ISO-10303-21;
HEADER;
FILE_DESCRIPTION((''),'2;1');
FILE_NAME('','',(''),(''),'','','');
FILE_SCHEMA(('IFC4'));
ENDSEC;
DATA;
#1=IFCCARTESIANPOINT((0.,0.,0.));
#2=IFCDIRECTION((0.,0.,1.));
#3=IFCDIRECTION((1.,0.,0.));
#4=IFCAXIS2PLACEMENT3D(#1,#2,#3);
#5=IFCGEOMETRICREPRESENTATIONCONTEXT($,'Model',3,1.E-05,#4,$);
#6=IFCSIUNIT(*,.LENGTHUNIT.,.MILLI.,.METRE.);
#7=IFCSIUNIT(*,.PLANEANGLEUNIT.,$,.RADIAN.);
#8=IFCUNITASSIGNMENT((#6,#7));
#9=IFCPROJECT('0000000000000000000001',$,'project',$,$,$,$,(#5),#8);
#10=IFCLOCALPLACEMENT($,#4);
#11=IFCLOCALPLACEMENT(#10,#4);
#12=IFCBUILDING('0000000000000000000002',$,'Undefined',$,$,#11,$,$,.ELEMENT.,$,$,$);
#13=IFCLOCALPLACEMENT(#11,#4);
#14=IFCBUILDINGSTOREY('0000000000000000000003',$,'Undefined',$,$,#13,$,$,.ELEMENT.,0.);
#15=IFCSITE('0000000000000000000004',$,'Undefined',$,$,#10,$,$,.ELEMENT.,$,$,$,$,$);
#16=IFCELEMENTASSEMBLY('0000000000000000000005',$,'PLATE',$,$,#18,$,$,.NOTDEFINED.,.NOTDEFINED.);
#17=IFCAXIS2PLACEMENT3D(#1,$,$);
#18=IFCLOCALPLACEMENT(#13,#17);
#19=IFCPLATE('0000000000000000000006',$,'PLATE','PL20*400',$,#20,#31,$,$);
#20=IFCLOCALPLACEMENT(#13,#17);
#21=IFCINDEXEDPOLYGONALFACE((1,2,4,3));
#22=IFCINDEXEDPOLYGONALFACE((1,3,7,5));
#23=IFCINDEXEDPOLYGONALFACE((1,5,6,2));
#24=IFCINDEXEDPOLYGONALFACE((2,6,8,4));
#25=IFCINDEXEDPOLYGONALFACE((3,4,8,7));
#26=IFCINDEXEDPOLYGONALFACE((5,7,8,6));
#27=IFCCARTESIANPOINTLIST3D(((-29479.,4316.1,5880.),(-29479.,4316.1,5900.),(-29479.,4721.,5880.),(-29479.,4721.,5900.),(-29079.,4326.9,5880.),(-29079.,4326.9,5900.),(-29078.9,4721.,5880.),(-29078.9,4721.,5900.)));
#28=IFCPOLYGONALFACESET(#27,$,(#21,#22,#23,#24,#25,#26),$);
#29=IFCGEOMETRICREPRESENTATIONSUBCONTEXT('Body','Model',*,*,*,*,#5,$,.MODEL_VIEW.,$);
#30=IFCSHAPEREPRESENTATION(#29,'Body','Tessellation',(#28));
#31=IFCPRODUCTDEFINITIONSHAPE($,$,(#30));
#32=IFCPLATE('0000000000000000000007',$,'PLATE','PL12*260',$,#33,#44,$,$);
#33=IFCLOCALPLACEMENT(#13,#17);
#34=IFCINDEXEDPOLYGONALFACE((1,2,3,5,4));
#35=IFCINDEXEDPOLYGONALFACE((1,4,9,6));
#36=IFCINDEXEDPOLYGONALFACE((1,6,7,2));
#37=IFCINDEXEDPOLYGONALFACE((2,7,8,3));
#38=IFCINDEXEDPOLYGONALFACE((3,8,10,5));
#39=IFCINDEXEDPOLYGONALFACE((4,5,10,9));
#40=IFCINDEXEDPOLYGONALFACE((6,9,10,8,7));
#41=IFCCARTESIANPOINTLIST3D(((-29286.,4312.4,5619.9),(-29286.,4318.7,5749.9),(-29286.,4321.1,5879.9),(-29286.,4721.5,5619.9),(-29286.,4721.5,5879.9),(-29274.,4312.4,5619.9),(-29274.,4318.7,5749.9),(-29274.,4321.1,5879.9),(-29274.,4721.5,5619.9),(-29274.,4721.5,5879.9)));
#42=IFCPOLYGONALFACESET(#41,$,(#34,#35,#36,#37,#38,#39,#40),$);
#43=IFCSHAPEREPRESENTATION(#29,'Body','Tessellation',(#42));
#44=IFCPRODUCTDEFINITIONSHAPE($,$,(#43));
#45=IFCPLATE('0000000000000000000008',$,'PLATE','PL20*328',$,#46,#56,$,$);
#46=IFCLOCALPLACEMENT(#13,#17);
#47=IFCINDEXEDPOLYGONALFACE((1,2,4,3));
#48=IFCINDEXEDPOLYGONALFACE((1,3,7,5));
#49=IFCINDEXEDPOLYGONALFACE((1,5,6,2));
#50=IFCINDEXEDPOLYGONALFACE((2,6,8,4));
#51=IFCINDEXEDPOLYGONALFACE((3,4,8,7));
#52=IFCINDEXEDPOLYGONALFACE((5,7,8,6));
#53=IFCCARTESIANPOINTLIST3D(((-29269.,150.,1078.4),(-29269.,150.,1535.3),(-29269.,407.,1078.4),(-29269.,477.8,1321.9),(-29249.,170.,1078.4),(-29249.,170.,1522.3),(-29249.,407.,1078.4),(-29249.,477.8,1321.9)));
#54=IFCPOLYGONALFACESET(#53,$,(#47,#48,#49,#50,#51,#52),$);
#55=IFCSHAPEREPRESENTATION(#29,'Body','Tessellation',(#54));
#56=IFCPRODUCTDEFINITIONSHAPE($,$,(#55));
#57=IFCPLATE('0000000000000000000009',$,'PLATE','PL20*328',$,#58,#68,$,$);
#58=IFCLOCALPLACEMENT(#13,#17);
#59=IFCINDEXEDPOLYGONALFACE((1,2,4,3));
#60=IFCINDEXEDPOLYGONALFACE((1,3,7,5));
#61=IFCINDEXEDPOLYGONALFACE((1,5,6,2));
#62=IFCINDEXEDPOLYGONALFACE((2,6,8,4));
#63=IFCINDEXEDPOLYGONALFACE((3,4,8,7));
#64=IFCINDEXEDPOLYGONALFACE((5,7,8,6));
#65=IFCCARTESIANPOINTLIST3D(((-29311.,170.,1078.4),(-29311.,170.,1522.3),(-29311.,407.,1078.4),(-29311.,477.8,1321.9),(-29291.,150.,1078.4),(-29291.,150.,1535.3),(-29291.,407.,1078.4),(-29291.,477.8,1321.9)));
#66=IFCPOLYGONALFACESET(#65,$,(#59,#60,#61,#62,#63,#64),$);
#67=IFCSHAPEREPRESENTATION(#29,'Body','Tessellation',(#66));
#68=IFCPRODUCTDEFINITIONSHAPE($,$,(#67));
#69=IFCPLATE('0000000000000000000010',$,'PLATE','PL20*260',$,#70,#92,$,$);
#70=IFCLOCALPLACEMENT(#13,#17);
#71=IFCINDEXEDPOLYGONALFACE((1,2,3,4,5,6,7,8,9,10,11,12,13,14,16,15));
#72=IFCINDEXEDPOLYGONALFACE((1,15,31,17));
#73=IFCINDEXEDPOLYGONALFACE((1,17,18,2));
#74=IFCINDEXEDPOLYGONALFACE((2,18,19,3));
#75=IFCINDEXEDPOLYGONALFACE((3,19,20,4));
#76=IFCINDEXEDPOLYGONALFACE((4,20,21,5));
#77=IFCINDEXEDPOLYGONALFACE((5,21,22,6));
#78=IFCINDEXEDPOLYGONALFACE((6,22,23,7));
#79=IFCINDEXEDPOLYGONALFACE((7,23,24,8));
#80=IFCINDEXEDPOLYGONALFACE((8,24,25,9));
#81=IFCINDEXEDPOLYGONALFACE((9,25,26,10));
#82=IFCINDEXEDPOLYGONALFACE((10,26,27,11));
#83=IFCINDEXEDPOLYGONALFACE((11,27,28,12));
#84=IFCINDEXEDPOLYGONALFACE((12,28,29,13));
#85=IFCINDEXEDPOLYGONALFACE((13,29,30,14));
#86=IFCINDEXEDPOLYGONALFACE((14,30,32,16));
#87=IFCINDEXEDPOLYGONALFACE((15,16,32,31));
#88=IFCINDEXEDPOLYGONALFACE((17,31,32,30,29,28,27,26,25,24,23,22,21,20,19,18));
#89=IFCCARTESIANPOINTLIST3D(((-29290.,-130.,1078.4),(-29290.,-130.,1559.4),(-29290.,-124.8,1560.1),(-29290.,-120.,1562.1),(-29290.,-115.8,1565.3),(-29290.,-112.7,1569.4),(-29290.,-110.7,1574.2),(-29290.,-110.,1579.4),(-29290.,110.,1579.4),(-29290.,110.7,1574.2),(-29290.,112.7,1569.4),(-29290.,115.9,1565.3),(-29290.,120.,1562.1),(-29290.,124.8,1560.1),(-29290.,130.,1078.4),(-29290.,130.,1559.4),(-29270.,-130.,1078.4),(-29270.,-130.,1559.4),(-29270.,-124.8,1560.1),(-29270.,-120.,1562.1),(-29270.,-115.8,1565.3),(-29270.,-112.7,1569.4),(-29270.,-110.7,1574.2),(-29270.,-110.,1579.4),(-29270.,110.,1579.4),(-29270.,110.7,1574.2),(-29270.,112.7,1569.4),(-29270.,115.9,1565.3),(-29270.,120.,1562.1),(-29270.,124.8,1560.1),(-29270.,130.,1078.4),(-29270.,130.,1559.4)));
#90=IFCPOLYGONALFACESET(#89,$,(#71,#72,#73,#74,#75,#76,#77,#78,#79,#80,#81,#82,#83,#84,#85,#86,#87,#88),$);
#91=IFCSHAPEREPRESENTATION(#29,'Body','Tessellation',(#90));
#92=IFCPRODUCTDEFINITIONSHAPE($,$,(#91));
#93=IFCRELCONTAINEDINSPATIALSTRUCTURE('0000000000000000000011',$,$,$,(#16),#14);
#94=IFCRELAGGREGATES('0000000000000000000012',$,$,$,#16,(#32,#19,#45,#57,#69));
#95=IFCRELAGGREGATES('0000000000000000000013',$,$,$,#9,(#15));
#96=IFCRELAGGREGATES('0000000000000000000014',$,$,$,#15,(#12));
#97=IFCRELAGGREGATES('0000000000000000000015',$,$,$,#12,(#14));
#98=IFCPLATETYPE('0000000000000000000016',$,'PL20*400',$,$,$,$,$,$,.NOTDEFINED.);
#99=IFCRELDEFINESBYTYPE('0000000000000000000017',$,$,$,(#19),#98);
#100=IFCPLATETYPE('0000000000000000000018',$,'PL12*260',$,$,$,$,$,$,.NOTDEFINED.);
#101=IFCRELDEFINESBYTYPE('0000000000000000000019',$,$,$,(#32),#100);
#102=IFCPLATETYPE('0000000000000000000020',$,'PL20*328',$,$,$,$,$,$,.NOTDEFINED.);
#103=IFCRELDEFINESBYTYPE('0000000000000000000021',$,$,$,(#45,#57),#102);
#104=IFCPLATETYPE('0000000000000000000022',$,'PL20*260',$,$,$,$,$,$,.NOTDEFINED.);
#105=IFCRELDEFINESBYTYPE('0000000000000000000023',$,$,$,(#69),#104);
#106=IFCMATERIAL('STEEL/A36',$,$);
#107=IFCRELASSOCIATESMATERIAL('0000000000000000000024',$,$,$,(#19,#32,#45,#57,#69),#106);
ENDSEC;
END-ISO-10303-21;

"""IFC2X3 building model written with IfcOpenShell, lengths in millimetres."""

from ifc_helpers import new_model, si_unit, frame, frame_2d, origin_with_axes, place, context, subcontext, project, spatial, polyline, circle_curve, parameter, trimmed, segment, composite_curve, outline, extrude, boolean, material, type_object, element, aggregate, save


model = new_model("IFC2X3")

# Units and contexts
model_context = context("Model", 3, precision=1e-05, world=origin_with_axes())
body_context = subcontext(model_context, "Body", "Model", "MODEL_VIEW")
ifc_project = project(units=[si_unit("LENGTHUNIT", "METRE", prefix="MILLI"), si_unit("PLANEANGLEUNIT", "RADIAN")], contexts=[model_context])

# Site, building, storey
site_placement = place(None, origin_with_axes())
site = spatial("IfcSite", under=ifc_project, at=site_placement, Name="Undefined", CompositionType="ELEMENT")
building_placement = place(site_placement, origin_with_axes())
building = spatial("IfcBuilding", under=site, at=building_placement, Name="Undefined", CompositionType="ELEMENT")
storey_placement = place(building_placement, origin_with_axes())
storey = spatial("IfcBuildingStorey", under=building, at=storey_placement, Name="Undefined", CompositionType="ELEMENT", Elevation=0.0)

# Element assembly, plates
assembly_1_placement = place(storey_placement, origin_with_axes())
assembly_1 = element("IfcElementAssembly", 1, at=assembly_1_placement, inside=storey, Name="PLATE", AssemblyPlace="NOTDEFINED", PredefinedType="NOTDEFINED")
ifc_material_1 = material(Name="STEEL/A36")
plate_type_1 = type_object("IfcPlateType", Name="PL20*400", PredefinedType="NOTDEFINED")
plate_1_placement = place(assembly_1_placement, frame((-29078.9, 4721.0, 5890.0), z_axis=(0.0, 0.0, 1.0), x_axis=(-1.0, 0.0, 0.0)))
plate_1 = element("IfcPlate", 2, at=plate_1_placement, type_object=plate_type_1, material=ifc_material_1, Name="PLATE", Description="PL20*400", context=body_context, shape_type="SweptSolid", body=[
    extrude(outline(polyline([(0.0, 0.0), (400.1, 0.0), (400.1, 404.9), (0.1, 394.1), (0.0, 0.0)])), frame((0.0, 0.0, -10.0), z_axis=(0.0, 0.0, 1.0), x_axis=(1.0, 0.0, 0.0)), (0.0, 0.0, 1.0), 20.0),
])
plate_type_2 = type_object("IfcPlateType", Name="PL12*260", PredefinedType="NOTDEFINED")
plate_2_placement = place(assembly_1_placement, frame((-29280.0, 4721.5, 5879.9), z_axis=(-1.0, 0.0, 0.0), x_axis=(0.0, 0.0, -1.0)))
plate_2 = element("IfcPlate", 3, at=plate_2_placement, type_object=plate_type_2, material=ifc_material_1, Name="PLATE", Description="PL12*260", context=body_context, shape_type="SweptSolid", body=[
    extrude(outline(polyline([(0.0, 0.0), (260.0, 0.0), (260.0, 409.1), (130.0, 402.7), (0.0, 400.3), (0.0, 0.0)])), frame((0.0, 0.0, -6.0), z_axis=(0.0, 0.0, 1.0), x_axis=(1.0, 0.0, 0.0)), (0.0, 0.0, 1.0), 12.0),
])
plate_type_3 = type_object("IfcPlateType", Name="PL20*328", PredefinedType="NOTDEFINED")
plate_3_placement = place(assembly_1_placement, frame((-29259.0, 150.0, 1535.3), z_axis=(-1.0, 0.0, 0.0), x_axis=(0.0, 0.83796, -0.545732)))
plate_3 = element("IfcPlate", 4, at=plate_3_placement, type_object=plate_type_3, material=ifc_material_1, Name="PLATE", Description="PL20*328", context=body_context, shape_type="CSG", body=[
    boolean("DIFFERENCE", extrude(outline(polyline([(0.0, 0.0), (391.1, 0.0), (464.7, 242.6), (249.4, 382.9), (0.0, 0.0)])), frame((0.0, 0.0, -10.0), z_axis=(0.0, 0.0, 1.0), x_axis=(1.0, 0.0, 0.0)), (0.0, 0.0, 1.0), 20.0), extrude(outline(polyline([(0.0, 0.0), (20.0, 0.0), (0.0, 20.0), (0.0, 0.0)])), frame((-1.4, -2.1, -10.0), z_axis=(0.545732, 0.83796, 0.0), x_axis=(0.0, 0.0, 1.0)), (0.0, 0.0, 1.0), 462.0)),
])
plate_4_placement = place(assembly_1_placement, frame((-29301.0, 150.0, 1535.3), z_axis=(-1.0, 0.0, 0.0), x_axis=(0.0, 0.83796, -0.545732)))
plate_4 = element("IfcPlate", 5, at=plate_4_placement, type_object=plate_type_3, material=ifc_material_1, Name="PLATE", Description="PL20*328", context=body_context, shape_type="CSG", body=[
    boolean("DIFFERENCE", extrude(outline(polyline([(0.0, 0.0), (391.1, 0.0), (464.7, 242.6), (249.4, 382.9), (0.0, 0.0)])), frame((0.0, 0.0, -10.0), z_axis=(0.0, 0.0, 1.0), x_axis=(1.0, 0.0, 0.0)), (0.0, 0.0, 1.0), 20.0), extrude(outline(polyline([(0.0, 0.0), (20.0, 0.0), (20.0, 20.0), (0.0, 0.0)])), frame((-1.4, -2.1, -10.0), z_axis=(0.545732, 0.83796, 0.0), x_axis=(0.0, 0.0, 1.0)), (0.0, 0.0, 1.0), 462.0)),
])
plate_type_4 = type_object("IfcPlateType", Name="PL20*260", PredefinedType="NOTDEFINED")
plate_5_placement = place(assembly_1_placement, frame((-29280.0, -130.0, 1078.4), z_axis=(1.0, 0.0, 0.0), x_axis=(0.0, 1.0, 0.0)))
plate_5 = element("IfcPlate", 6, at=plate_5_placement, type_object=plate_type_4, material=ifc_material_1, Name="PLATE", Description="PL20*260", context=body_context, shape_type="SweptSolid", body=[
    extrude(outline(composite_curve([segment(polyline([(0.0, 0.0), (260.0, 0.0), (260.0, 481.0)]), True, "CONTINUOUS"), segment(trimmed(circle_curve(frame_2d((260.0, 501.0), x_axis=(0.0, -1.0)), 20.0), [parameter(0.0)], [parameter(4.712389)], False, "PARAMETER"), True, "CONTINUOUS"), segment(polyline([(240.0, 501.0), (20.0, 501.0)]), True, "CONTINUOUS"), segment(trimmed(circle_curve(frame_2d((0.0, 501.0), x_axis=(1.0, 0.0)), 20.0), [parameter(0.0)], [parameter(4.71237)], False, "PARAMETER"), True, "CONTINUOUS"), segment(polyline([(0.0, 481.0), (0.0, 0.0)]), True, "CONTINUOUS")], self_intersect=True)), frame((0.0, 0.0, -10.0), z_axis=(0.0, 0.0, 1.0), x_axis=(1.0, 0.0, 0.0)), (0.0, 0.0, 1.0), 20.0),
])
aggregate(assembly_1, [plate_2, plate_1, plate_3, plate_4, plate_5])

save(model, "model.ifc")
